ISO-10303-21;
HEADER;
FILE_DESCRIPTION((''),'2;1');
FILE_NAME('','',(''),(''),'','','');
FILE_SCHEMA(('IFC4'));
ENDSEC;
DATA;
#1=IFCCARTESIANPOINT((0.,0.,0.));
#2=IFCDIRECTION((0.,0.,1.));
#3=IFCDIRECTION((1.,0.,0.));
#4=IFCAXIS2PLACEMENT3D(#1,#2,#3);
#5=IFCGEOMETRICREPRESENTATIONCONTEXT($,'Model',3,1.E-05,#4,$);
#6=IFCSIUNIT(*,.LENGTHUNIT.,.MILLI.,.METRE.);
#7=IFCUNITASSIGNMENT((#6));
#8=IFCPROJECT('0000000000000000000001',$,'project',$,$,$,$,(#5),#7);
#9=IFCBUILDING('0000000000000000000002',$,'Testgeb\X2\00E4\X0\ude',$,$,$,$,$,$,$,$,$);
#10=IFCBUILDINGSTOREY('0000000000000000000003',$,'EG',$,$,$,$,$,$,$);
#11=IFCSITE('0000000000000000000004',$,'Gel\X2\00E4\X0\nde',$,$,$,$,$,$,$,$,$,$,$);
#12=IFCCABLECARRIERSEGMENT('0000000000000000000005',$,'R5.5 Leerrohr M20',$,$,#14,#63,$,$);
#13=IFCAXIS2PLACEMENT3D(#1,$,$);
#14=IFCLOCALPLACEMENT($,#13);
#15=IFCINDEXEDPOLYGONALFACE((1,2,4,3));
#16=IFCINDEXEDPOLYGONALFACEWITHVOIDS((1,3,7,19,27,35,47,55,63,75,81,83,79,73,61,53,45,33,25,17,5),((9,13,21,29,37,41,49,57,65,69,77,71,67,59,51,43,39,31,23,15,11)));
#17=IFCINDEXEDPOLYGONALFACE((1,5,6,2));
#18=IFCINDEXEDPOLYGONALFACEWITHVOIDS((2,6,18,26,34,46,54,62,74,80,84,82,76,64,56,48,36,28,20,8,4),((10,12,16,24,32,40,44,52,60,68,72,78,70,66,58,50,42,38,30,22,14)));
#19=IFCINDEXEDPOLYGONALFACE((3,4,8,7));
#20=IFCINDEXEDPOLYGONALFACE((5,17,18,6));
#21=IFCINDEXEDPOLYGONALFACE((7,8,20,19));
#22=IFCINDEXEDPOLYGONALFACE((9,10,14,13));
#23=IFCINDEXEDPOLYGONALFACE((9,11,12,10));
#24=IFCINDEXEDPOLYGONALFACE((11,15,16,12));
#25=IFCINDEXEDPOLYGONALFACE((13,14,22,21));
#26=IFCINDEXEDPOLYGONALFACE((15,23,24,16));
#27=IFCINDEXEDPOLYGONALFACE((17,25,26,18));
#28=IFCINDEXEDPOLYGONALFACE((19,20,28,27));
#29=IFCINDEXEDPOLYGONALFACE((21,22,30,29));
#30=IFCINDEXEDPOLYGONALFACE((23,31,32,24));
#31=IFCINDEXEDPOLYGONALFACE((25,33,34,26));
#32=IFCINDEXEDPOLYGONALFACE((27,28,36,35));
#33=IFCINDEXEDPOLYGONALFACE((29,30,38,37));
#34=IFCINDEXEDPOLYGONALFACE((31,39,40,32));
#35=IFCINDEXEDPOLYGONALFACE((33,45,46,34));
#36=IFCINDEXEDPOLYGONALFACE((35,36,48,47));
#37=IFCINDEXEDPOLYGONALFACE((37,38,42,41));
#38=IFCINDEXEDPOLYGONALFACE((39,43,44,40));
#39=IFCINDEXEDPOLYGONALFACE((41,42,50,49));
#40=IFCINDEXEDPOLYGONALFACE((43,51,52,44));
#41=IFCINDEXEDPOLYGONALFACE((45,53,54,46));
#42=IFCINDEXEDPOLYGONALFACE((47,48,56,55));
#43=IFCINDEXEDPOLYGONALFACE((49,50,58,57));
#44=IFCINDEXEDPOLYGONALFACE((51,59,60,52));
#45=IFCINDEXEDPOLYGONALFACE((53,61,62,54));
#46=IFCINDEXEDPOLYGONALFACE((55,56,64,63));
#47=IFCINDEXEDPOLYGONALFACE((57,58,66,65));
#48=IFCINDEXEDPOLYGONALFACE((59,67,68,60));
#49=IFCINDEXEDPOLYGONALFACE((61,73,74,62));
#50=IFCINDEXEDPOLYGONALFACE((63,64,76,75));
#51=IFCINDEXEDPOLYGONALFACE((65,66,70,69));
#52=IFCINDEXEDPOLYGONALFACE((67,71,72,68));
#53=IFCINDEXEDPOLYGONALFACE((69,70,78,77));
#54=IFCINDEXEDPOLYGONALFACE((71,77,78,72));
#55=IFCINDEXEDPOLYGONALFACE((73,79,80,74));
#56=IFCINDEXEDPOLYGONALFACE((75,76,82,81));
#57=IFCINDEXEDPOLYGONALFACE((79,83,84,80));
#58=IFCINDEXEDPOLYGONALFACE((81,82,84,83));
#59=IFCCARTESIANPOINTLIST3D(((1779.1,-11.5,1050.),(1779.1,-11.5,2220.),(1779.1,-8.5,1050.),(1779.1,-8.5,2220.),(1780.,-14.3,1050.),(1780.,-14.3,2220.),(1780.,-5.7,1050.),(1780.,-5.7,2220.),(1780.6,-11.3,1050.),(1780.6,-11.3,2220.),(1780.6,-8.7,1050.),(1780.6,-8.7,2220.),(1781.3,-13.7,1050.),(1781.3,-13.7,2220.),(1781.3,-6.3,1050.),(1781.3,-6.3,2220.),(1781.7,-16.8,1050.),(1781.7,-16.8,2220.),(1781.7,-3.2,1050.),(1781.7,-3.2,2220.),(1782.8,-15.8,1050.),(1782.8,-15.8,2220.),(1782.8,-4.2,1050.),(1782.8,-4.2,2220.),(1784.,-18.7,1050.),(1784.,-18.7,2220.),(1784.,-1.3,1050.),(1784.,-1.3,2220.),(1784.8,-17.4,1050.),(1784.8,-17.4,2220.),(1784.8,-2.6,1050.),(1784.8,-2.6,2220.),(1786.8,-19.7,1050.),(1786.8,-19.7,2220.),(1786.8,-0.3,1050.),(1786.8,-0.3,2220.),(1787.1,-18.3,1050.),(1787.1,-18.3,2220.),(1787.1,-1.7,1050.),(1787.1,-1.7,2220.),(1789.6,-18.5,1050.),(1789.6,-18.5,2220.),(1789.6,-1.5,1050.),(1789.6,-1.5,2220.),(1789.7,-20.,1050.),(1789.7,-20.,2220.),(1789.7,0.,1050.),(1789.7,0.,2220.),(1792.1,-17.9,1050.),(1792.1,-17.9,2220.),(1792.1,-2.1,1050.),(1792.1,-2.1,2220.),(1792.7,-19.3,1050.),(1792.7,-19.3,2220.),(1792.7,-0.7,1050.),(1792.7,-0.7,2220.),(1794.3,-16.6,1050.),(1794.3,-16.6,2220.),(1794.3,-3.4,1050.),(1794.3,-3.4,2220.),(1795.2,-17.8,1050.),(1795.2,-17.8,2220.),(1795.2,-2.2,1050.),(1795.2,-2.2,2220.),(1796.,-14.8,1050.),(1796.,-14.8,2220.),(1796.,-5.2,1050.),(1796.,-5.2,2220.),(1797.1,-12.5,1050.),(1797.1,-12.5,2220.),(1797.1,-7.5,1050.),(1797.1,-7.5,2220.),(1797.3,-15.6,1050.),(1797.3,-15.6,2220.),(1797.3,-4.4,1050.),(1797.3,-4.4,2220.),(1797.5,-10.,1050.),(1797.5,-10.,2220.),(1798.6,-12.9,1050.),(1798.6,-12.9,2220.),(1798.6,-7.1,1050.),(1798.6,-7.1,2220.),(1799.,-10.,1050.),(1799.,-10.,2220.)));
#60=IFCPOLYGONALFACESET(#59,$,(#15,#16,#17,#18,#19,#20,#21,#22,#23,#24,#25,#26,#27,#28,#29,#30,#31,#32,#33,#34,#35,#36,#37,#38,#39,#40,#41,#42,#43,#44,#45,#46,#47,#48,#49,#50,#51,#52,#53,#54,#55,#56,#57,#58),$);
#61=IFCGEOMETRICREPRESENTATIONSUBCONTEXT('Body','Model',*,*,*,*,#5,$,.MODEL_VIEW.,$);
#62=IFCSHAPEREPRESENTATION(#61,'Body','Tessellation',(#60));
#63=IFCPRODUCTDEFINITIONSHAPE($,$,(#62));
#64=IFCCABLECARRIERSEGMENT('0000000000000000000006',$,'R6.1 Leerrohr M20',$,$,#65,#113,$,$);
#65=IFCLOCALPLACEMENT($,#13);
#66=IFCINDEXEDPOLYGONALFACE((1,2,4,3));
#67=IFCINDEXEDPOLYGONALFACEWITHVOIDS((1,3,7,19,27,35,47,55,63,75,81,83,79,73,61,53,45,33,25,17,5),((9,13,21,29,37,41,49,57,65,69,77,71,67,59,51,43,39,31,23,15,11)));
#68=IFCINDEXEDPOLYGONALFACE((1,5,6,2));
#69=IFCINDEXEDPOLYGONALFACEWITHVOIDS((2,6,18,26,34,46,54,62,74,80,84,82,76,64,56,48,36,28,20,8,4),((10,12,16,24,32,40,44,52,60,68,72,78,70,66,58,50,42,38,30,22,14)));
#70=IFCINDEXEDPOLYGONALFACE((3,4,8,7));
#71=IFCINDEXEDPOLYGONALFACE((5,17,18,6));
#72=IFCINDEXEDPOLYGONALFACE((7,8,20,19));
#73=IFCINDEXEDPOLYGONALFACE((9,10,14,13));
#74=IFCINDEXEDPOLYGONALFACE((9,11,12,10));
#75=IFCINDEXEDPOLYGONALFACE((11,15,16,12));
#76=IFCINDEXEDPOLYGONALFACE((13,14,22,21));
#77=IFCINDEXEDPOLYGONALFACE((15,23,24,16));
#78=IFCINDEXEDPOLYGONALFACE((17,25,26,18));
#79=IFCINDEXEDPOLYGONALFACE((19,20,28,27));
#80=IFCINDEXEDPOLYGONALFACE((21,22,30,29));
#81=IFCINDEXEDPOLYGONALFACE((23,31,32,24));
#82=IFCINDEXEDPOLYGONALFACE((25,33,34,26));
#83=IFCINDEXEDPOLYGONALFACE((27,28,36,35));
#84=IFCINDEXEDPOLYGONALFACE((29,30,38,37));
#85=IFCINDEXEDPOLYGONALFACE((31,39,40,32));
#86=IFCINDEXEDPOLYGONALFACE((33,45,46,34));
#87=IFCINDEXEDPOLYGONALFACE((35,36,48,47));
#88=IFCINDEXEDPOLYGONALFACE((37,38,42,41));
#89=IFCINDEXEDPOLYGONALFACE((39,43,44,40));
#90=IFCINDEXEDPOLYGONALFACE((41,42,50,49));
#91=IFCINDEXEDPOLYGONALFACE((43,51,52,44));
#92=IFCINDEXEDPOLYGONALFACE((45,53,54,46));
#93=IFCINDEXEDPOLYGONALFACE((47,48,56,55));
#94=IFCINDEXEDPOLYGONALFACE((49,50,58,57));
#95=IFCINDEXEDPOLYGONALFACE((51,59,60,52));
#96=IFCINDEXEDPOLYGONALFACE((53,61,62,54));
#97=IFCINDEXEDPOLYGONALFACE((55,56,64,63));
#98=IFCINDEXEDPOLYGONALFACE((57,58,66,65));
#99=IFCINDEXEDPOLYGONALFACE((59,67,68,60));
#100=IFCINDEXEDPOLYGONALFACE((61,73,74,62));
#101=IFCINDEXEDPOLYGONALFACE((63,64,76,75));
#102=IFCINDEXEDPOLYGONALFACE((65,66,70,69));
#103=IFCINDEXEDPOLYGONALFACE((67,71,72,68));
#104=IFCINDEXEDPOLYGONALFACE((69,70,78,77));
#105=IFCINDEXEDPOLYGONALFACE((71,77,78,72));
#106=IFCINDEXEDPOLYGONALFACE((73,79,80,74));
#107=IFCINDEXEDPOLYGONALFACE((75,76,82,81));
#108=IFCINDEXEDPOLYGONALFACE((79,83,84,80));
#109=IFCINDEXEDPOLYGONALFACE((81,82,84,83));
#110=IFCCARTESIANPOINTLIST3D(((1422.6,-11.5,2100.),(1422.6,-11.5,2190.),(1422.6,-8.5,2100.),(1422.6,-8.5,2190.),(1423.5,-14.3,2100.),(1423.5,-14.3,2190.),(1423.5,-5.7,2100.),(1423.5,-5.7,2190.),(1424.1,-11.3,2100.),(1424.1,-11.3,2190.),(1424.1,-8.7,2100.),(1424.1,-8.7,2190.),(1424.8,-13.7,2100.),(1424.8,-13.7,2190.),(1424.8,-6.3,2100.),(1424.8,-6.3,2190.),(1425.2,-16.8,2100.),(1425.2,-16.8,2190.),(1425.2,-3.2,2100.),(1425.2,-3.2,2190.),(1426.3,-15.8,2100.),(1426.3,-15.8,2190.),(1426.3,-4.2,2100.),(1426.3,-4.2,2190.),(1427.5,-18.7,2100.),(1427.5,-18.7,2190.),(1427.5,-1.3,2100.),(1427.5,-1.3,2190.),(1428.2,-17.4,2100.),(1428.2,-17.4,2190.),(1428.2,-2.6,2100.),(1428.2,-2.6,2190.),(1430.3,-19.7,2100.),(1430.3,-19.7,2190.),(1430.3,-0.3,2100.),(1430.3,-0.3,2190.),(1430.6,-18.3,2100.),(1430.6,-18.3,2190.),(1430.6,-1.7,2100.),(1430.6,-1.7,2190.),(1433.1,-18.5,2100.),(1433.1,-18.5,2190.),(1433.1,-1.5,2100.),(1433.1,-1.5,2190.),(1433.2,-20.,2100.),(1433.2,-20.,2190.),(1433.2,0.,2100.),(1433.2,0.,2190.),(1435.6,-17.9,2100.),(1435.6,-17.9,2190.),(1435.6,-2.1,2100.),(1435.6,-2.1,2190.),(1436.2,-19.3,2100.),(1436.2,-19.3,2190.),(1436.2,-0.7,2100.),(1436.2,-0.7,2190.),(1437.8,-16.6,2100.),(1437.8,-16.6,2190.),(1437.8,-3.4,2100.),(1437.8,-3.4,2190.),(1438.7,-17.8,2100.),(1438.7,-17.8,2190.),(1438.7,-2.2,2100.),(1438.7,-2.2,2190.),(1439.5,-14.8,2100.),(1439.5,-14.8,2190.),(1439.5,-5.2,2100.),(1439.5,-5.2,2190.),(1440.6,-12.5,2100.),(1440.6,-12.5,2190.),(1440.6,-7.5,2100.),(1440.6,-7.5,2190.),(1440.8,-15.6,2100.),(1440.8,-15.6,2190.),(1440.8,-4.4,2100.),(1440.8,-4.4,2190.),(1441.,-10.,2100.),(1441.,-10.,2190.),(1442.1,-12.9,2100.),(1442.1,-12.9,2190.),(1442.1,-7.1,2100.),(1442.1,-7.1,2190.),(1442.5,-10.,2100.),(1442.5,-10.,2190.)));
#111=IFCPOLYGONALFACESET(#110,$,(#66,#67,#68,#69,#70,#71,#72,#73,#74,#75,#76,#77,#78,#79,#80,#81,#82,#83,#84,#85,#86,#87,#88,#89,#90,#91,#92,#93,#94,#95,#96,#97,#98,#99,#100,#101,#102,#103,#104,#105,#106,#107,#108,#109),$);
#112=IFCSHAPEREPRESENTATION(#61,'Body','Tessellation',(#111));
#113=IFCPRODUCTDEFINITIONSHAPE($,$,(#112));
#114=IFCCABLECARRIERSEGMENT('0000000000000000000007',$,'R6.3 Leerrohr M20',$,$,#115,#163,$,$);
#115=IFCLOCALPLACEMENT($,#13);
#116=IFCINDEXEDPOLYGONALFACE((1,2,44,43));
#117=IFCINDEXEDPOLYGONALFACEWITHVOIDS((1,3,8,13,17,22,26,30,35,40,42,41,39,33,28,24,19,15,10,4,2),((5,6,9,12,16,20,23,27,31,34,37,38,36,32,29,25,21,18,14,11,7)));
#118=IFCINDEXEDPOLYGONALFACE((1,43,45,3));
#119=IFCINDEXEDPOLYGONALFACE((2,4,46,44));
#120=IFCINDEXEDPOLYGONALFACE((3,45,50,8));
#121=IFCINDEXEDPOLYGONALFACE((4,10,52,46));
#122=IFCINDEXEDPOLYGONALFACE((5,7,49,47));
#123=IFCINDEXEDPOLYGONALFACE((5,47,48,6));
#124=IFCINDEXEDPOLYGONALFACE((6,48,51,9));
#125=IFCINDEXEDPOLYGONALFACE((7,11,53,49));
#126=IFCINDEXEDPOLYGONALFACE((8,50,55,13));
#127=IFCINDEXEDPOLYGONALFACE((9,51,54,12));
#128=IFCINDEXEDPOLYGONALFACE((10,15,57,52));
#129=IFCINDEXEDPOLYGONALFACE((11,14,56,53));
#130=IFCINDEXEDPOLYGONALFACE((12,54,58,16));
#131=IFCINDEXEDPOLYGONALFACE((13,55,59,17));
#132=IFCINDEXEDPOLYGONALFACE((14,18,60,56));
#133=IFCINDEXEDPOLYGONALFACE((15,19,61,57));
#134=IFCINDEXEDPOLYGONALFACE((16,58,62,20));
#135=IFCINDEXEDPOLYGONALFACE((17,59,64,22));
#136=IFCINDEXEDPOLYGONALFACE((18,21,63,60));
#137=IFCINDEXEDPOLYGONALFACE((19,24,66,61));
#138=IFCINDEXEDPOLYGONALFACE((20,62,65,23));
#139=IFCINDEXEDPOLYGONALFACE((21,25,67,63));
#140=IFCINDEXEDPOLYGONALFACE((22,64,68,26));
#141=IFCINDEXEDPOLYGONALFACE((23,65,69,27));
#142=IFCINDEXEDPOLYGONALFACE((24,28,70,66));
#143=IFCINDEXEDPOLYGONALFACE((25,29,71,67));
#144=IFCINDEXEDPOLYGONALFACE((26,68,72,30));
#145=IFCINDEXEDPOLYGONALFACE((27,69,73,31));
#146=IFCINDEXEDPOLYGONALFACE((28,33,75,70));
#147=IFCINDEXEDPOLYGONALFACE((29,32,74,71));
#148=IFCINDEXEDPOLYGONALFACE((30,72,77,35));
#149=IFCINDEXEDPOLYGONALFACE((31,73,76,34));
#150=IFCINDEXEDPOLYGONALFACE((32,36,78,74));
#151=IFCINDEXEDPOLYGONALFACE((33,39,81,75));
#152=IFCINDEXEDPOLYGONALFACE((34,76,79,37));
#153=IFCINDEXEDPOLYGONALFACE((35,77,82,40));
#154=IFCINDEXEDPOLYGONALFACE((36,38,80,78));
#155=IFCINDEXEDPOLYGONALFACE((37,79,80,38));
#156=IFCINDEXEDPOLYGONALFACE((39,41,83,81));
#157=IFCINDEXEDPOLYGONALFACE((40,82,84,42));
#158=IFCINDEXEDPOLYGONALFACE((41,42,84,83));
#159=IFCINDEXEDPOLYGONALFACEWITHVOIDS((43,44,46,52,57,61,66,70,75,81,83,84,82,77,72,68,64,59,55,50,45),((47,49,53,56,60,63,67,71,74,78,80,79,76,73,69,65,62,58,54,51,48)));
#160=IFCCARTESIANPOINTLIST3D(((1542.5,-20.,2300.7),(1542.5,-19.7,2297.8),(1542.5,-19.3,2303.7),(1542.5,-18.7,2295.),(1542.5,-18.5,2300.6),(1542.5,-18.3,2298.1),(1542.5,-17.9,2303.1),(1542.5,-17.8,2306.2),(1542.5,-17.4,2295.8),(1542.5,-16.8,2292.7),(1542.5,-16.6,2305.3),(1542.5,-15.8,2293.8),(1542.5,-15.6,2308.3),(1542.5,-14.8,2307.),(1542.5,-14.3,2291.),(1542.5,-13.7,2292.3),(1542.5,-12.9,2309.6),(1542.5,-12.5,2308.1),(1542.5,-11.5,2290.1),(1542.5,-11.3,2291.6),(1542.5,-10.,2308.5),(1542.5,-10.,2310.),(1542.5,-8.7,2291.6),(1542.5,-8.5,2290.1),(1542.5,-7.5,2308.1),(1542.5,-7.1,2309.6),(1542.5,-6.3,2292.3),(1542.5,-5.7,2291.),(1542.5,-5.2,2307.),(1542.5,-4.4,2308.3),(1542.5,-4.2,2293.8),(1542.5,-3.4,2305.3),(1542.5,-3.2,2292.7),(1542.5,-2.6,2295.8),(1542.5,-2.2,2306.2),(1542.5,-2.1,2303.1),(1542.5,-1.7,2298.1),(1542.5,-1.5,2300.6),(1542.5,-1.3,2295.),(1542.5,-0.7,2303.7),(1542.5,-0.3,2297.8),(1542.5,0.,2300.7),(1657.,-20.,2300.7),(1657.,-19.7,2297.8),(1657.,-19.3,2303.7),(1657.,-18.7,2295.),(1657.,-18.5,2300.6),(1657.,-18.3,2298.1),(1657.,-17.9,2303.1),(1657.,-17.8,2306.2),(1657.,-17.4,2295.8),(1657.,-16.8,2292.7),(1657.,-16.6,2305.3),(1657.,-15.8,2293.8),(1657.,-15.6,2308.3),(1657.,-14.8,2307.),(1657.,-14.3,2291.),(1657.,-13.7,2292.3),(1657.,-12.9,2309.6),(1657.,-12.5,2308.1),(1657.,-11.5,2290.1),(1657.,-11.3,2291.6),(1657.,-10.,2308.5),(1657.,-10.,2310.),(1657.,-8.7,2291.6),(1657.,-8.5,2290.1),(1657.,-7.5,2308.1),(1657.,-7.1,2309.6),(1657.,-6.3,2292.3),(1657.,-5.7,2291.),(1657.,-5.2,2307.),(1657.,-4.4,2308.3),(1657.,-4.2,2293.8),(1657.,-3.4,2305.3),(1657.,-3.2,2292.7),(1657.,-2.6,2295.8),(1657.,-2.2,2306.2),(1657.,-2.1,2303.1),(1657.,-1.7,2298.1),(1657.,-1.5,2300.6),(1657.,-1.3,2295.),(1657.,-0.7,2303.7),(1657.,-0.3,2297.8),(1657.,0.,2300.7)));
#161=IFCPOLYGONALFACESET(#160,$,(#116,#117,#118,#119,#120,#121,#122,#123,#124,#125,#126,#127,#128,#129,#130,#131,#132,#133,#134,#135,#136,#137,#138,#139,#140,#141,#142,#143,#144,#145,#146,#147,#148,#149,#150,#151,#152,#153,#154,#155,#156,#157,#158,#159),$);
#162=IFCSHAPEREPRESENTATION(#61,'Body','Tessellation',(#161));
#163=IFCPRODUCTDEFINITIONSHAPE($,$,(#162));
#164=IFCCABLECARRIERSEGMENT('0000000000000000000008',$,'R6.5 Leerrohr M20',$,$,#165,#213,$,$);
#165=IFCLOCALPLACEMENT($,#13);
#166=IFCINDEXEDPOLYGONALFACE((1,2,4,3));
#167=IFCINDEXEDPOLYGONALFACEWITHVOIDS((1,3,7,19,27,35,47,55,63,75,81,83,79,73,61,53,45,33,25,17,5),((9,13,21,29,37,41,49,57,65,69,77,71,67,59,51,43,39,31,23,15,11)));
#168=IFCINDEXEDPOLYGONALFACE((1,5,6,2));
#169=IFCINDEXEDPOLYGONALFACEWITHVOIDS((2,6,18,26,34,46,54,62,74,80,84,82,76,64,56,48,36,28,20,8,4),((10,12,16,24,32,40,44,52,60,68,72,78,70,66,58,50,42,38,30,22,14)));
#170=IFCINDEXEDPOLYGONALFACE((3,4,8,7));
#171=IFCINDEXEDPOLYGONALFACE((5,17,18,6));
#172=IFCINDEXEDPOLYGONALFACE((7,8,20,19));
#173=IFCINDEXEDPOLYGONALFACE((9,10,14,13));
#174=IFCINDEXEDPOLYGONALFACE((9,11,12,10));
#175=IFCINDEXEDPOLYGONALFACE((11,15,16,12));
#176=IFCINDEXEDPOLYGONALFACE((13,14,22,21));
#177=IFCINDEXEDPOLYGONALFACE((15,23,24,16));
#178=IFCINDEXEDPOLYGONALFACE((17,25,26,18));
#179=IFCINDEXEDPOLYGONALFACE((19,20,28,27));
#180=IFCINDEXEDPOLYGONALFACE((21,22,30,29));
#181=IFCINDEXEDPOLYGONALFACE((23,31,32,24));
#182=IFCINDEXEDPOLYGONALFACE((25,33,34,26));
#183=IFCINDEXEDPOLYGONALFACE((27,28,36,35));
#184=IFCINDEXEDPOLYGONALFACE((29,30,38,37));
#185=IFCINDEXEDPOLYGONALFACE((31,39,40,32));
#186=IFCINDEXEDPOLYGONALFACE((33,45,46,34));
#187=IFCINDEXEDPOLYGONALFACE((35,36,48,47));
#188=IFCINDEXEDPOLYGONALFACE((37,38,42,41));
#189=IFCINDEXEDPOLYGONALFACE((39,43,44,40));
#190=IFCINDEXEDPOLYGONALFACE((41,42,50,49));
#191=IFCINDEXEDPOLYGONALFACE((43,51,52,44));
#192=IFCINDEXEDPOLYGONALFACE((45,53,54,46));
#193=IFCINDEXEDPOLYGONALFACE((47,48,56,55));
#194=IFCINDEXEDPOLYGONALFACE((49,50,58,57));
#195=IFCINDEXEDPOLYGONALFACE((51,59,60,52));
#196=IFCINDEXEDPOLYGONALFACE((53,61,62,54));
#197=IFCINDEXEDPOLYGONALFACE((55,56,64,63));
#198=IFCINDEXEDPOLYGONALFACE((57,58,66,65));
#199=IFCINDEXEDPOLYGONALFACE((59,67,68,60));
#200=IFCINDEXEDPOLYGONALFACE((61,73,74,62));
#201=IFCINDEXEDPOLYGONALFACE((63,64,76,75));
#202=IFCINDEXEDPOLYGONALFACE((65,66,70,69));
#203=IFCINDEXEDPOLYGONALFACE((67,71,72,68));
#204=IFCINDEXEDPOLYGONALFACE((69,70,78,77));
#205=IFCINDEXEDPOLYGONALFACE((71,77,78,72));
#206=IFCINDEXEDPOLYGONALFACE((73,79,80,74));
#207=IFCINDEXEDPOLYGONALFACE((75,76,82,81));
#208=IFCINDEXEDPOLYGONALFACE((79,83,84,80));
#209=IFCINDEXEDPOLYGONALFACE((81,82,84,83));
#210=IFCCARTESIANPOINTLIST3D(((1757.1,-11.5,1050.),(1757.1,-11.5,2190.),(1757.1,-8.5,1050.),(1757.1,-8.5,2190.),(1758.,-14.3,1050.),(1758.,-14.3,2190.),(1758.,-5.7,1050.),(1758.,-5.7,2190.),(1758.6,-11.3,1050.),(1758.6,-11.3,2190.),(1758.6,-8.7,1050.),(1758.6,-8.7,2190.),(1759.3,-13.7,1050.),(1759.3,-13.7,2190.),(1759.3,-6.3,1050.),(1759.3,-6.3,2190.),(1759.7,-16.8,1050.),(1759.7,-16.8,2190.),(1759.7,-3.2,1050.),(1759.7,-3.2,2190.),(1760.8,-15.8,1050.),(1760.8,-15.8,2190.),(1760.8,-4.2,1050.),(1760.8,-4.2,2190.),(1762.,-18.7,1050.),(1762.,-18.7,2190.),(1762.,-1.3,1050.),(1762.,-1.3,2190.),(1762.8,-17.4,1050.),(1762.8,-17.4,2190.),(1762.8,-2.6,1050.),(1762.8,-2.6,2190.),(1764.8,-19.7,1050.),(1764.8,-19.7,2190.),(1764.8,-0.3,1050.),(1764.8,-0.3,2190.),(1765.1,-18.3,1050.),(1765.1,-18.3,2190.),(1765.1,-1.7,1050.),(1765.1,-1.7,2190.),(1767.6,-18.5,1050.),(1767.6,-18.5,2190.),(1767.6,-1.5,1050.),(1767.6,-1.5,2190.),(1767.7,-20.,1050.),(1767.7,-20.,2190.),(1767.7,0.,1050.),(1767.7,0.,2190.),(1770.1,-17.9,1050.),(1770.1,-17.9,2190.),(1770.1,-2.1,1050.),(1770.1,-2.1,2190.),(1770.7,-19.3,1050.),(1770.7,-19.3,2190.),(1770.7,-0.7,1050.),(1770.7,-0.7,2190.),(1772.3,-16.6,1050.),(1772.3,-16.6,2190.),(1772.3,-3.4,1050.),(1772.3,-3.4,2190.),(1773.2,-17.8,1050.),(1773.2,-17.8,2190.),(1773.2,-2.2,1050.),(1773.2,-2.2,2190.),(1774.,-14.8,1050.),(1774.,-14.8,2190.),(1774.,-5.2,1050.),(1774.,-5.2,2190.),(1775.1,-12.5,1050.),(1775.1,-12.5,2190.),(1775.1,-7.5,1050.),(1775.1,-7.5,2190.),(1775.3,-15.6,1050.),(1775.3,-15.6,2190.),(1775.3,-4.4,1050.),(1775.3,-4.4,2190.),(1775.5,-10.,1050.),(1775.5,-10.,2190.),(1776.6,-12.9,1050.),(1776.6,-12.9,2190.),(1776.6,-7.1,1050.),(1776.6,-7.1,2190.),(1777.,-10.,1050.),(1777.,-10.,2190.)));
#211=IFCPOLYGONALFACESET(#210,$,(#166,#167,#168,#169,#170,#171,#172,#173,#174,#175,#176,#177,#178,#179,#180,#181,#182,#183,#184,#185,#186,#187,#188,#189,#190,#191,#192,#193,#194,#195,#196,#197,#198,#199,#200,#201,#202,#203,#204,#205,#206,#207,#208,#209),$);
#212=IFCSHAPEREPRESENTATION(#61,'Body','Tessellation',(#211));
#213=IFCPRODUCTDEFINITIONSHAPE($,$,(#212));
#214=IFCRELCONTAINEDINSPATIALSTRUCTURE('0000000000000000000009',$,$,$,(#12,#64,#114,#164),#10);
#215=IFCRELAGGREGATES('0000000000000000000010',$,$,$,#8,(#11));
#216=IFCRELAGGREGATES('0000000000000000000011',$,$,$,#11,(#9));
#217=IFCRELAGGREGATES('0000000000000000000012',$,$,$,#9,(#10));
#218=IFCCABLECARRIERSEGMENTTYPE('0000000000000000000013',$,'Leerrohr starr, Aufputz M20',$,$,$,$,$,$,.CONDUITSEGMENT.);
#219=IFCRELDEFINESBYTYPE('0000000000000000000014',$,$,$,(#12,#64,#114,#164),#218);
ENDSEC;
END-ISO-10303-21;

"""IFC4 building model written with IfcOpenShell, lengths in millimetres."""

from ifc_helpers import new_model, si_unit, frame, origin_with_axes, place, context, subcontext, project, spatial, hollow_circle, extrude, type_object, element, save


model = new_model("IFC4")

# Units and contexts
model_context = context("Model", 3, precision=1e-05, world=origin_with_axes())
body_context = subcontext(model_context, "Body", "Model", "MODEL_VIEW")
ifc_project = project(units=[si_unit("LENGTHUNIT", "METRE", prefix="MILLI")], contexts=[model_context])

# Site, building, storey
site = spatial("IfcSite", under=ifc_project, Name="Gelände")
building = spatial("IfcBuilding", under=site, Name="Testgebäude")
storey = spatial("IfcBuildingStorey", under=building, Name="EG")

# Cable carrier segments
cable_carrier_segment_type_1 = type_object("IfcCableCarrierSegmentType", Name="Leerrohr starr, Aufputz M20", PredefinedType="CONDUITSEGMENT")
cable_carrier_segment_1_placement = place(None, frame((1789.0, -10.0, 2220.0), z_axis=(0.0, 0.0, -1.0), x_axis=(1.0, 0.0, 0.0)))
element("IfcCableCarrierSegment", 1, at=cable_carrier_segment_1_placement, inside=storey, type_object=cable_carrier_segment_type_1, Name="R5.5 Leerrohr M20", context=body_context, shape_type="SweptSolid", body=[
    extrude(hollow_circle(Radius=10.0, WallThickness=1.5), None, (0.0, 0.0, 1.0), 1170.0),
])
cable_carrier_segment_2_placement = place(None, frame((1432.5, -10.0, 2100.0), z_axis=(0.0, 0.0, 1.0), x_axis=(1.0, 0.0, 0.0)))
element("IfcCableCarrierSegment", 2, at=cable_carrier_segment_2_placement, inside=storey, type_object=cable_carrier_segment_type_1, Name="R6.1 Leerrohr M20", context=body_context, shape_type="SweptSolid", body=[
    extrude(hollow_circle(Radius=10.0, WallThickness=1.5), None, (0.0, 0.0, 1.0), 90.0),
])
cable_carrier_segment_3_placement = place(None, frame((1542.5, -10.0, 2300.0), z_axis=(1.0, 0.0, 0.0), x_axis=(0.0, 0.0, 1.0)))
element("IfcCableCarrierSegment", 3, at=cable_carrier_segment_3_placement, inside=storey, type_object=cable_carrier_segment_type_1, Name="R6.3 Leerrohr M20", context=body_context, shape_type="SweptSolid", body=[
    extrude(hollow_circle(Radius=10.0, WallThickness=1.5), None, (0.0, 0.0, 1.0), 114.5),
])
cable_carrier_segment_4_placement = place(None, frame((1767.0, -10.0, 2190.0), z_axis=(0.0, 0.0, -1.0), x_axis=(1.0, 0.0, 0.0)))
element("IfcCableCarrierSegment", 4, at=cable_carrier_segment_4_placement, inside=storey, type_object=cable_carrier_segment_type_1, Name="R6.5 Leerrohr M20", context=body_context, shape_type="SweptSolid", body=[
    extrude(hollow_circle(Radius=10.0, WallThickness=1.5), None, (0.0, 0.0, 1.0), 1140.0),
])

save(model, "model.ifc")
